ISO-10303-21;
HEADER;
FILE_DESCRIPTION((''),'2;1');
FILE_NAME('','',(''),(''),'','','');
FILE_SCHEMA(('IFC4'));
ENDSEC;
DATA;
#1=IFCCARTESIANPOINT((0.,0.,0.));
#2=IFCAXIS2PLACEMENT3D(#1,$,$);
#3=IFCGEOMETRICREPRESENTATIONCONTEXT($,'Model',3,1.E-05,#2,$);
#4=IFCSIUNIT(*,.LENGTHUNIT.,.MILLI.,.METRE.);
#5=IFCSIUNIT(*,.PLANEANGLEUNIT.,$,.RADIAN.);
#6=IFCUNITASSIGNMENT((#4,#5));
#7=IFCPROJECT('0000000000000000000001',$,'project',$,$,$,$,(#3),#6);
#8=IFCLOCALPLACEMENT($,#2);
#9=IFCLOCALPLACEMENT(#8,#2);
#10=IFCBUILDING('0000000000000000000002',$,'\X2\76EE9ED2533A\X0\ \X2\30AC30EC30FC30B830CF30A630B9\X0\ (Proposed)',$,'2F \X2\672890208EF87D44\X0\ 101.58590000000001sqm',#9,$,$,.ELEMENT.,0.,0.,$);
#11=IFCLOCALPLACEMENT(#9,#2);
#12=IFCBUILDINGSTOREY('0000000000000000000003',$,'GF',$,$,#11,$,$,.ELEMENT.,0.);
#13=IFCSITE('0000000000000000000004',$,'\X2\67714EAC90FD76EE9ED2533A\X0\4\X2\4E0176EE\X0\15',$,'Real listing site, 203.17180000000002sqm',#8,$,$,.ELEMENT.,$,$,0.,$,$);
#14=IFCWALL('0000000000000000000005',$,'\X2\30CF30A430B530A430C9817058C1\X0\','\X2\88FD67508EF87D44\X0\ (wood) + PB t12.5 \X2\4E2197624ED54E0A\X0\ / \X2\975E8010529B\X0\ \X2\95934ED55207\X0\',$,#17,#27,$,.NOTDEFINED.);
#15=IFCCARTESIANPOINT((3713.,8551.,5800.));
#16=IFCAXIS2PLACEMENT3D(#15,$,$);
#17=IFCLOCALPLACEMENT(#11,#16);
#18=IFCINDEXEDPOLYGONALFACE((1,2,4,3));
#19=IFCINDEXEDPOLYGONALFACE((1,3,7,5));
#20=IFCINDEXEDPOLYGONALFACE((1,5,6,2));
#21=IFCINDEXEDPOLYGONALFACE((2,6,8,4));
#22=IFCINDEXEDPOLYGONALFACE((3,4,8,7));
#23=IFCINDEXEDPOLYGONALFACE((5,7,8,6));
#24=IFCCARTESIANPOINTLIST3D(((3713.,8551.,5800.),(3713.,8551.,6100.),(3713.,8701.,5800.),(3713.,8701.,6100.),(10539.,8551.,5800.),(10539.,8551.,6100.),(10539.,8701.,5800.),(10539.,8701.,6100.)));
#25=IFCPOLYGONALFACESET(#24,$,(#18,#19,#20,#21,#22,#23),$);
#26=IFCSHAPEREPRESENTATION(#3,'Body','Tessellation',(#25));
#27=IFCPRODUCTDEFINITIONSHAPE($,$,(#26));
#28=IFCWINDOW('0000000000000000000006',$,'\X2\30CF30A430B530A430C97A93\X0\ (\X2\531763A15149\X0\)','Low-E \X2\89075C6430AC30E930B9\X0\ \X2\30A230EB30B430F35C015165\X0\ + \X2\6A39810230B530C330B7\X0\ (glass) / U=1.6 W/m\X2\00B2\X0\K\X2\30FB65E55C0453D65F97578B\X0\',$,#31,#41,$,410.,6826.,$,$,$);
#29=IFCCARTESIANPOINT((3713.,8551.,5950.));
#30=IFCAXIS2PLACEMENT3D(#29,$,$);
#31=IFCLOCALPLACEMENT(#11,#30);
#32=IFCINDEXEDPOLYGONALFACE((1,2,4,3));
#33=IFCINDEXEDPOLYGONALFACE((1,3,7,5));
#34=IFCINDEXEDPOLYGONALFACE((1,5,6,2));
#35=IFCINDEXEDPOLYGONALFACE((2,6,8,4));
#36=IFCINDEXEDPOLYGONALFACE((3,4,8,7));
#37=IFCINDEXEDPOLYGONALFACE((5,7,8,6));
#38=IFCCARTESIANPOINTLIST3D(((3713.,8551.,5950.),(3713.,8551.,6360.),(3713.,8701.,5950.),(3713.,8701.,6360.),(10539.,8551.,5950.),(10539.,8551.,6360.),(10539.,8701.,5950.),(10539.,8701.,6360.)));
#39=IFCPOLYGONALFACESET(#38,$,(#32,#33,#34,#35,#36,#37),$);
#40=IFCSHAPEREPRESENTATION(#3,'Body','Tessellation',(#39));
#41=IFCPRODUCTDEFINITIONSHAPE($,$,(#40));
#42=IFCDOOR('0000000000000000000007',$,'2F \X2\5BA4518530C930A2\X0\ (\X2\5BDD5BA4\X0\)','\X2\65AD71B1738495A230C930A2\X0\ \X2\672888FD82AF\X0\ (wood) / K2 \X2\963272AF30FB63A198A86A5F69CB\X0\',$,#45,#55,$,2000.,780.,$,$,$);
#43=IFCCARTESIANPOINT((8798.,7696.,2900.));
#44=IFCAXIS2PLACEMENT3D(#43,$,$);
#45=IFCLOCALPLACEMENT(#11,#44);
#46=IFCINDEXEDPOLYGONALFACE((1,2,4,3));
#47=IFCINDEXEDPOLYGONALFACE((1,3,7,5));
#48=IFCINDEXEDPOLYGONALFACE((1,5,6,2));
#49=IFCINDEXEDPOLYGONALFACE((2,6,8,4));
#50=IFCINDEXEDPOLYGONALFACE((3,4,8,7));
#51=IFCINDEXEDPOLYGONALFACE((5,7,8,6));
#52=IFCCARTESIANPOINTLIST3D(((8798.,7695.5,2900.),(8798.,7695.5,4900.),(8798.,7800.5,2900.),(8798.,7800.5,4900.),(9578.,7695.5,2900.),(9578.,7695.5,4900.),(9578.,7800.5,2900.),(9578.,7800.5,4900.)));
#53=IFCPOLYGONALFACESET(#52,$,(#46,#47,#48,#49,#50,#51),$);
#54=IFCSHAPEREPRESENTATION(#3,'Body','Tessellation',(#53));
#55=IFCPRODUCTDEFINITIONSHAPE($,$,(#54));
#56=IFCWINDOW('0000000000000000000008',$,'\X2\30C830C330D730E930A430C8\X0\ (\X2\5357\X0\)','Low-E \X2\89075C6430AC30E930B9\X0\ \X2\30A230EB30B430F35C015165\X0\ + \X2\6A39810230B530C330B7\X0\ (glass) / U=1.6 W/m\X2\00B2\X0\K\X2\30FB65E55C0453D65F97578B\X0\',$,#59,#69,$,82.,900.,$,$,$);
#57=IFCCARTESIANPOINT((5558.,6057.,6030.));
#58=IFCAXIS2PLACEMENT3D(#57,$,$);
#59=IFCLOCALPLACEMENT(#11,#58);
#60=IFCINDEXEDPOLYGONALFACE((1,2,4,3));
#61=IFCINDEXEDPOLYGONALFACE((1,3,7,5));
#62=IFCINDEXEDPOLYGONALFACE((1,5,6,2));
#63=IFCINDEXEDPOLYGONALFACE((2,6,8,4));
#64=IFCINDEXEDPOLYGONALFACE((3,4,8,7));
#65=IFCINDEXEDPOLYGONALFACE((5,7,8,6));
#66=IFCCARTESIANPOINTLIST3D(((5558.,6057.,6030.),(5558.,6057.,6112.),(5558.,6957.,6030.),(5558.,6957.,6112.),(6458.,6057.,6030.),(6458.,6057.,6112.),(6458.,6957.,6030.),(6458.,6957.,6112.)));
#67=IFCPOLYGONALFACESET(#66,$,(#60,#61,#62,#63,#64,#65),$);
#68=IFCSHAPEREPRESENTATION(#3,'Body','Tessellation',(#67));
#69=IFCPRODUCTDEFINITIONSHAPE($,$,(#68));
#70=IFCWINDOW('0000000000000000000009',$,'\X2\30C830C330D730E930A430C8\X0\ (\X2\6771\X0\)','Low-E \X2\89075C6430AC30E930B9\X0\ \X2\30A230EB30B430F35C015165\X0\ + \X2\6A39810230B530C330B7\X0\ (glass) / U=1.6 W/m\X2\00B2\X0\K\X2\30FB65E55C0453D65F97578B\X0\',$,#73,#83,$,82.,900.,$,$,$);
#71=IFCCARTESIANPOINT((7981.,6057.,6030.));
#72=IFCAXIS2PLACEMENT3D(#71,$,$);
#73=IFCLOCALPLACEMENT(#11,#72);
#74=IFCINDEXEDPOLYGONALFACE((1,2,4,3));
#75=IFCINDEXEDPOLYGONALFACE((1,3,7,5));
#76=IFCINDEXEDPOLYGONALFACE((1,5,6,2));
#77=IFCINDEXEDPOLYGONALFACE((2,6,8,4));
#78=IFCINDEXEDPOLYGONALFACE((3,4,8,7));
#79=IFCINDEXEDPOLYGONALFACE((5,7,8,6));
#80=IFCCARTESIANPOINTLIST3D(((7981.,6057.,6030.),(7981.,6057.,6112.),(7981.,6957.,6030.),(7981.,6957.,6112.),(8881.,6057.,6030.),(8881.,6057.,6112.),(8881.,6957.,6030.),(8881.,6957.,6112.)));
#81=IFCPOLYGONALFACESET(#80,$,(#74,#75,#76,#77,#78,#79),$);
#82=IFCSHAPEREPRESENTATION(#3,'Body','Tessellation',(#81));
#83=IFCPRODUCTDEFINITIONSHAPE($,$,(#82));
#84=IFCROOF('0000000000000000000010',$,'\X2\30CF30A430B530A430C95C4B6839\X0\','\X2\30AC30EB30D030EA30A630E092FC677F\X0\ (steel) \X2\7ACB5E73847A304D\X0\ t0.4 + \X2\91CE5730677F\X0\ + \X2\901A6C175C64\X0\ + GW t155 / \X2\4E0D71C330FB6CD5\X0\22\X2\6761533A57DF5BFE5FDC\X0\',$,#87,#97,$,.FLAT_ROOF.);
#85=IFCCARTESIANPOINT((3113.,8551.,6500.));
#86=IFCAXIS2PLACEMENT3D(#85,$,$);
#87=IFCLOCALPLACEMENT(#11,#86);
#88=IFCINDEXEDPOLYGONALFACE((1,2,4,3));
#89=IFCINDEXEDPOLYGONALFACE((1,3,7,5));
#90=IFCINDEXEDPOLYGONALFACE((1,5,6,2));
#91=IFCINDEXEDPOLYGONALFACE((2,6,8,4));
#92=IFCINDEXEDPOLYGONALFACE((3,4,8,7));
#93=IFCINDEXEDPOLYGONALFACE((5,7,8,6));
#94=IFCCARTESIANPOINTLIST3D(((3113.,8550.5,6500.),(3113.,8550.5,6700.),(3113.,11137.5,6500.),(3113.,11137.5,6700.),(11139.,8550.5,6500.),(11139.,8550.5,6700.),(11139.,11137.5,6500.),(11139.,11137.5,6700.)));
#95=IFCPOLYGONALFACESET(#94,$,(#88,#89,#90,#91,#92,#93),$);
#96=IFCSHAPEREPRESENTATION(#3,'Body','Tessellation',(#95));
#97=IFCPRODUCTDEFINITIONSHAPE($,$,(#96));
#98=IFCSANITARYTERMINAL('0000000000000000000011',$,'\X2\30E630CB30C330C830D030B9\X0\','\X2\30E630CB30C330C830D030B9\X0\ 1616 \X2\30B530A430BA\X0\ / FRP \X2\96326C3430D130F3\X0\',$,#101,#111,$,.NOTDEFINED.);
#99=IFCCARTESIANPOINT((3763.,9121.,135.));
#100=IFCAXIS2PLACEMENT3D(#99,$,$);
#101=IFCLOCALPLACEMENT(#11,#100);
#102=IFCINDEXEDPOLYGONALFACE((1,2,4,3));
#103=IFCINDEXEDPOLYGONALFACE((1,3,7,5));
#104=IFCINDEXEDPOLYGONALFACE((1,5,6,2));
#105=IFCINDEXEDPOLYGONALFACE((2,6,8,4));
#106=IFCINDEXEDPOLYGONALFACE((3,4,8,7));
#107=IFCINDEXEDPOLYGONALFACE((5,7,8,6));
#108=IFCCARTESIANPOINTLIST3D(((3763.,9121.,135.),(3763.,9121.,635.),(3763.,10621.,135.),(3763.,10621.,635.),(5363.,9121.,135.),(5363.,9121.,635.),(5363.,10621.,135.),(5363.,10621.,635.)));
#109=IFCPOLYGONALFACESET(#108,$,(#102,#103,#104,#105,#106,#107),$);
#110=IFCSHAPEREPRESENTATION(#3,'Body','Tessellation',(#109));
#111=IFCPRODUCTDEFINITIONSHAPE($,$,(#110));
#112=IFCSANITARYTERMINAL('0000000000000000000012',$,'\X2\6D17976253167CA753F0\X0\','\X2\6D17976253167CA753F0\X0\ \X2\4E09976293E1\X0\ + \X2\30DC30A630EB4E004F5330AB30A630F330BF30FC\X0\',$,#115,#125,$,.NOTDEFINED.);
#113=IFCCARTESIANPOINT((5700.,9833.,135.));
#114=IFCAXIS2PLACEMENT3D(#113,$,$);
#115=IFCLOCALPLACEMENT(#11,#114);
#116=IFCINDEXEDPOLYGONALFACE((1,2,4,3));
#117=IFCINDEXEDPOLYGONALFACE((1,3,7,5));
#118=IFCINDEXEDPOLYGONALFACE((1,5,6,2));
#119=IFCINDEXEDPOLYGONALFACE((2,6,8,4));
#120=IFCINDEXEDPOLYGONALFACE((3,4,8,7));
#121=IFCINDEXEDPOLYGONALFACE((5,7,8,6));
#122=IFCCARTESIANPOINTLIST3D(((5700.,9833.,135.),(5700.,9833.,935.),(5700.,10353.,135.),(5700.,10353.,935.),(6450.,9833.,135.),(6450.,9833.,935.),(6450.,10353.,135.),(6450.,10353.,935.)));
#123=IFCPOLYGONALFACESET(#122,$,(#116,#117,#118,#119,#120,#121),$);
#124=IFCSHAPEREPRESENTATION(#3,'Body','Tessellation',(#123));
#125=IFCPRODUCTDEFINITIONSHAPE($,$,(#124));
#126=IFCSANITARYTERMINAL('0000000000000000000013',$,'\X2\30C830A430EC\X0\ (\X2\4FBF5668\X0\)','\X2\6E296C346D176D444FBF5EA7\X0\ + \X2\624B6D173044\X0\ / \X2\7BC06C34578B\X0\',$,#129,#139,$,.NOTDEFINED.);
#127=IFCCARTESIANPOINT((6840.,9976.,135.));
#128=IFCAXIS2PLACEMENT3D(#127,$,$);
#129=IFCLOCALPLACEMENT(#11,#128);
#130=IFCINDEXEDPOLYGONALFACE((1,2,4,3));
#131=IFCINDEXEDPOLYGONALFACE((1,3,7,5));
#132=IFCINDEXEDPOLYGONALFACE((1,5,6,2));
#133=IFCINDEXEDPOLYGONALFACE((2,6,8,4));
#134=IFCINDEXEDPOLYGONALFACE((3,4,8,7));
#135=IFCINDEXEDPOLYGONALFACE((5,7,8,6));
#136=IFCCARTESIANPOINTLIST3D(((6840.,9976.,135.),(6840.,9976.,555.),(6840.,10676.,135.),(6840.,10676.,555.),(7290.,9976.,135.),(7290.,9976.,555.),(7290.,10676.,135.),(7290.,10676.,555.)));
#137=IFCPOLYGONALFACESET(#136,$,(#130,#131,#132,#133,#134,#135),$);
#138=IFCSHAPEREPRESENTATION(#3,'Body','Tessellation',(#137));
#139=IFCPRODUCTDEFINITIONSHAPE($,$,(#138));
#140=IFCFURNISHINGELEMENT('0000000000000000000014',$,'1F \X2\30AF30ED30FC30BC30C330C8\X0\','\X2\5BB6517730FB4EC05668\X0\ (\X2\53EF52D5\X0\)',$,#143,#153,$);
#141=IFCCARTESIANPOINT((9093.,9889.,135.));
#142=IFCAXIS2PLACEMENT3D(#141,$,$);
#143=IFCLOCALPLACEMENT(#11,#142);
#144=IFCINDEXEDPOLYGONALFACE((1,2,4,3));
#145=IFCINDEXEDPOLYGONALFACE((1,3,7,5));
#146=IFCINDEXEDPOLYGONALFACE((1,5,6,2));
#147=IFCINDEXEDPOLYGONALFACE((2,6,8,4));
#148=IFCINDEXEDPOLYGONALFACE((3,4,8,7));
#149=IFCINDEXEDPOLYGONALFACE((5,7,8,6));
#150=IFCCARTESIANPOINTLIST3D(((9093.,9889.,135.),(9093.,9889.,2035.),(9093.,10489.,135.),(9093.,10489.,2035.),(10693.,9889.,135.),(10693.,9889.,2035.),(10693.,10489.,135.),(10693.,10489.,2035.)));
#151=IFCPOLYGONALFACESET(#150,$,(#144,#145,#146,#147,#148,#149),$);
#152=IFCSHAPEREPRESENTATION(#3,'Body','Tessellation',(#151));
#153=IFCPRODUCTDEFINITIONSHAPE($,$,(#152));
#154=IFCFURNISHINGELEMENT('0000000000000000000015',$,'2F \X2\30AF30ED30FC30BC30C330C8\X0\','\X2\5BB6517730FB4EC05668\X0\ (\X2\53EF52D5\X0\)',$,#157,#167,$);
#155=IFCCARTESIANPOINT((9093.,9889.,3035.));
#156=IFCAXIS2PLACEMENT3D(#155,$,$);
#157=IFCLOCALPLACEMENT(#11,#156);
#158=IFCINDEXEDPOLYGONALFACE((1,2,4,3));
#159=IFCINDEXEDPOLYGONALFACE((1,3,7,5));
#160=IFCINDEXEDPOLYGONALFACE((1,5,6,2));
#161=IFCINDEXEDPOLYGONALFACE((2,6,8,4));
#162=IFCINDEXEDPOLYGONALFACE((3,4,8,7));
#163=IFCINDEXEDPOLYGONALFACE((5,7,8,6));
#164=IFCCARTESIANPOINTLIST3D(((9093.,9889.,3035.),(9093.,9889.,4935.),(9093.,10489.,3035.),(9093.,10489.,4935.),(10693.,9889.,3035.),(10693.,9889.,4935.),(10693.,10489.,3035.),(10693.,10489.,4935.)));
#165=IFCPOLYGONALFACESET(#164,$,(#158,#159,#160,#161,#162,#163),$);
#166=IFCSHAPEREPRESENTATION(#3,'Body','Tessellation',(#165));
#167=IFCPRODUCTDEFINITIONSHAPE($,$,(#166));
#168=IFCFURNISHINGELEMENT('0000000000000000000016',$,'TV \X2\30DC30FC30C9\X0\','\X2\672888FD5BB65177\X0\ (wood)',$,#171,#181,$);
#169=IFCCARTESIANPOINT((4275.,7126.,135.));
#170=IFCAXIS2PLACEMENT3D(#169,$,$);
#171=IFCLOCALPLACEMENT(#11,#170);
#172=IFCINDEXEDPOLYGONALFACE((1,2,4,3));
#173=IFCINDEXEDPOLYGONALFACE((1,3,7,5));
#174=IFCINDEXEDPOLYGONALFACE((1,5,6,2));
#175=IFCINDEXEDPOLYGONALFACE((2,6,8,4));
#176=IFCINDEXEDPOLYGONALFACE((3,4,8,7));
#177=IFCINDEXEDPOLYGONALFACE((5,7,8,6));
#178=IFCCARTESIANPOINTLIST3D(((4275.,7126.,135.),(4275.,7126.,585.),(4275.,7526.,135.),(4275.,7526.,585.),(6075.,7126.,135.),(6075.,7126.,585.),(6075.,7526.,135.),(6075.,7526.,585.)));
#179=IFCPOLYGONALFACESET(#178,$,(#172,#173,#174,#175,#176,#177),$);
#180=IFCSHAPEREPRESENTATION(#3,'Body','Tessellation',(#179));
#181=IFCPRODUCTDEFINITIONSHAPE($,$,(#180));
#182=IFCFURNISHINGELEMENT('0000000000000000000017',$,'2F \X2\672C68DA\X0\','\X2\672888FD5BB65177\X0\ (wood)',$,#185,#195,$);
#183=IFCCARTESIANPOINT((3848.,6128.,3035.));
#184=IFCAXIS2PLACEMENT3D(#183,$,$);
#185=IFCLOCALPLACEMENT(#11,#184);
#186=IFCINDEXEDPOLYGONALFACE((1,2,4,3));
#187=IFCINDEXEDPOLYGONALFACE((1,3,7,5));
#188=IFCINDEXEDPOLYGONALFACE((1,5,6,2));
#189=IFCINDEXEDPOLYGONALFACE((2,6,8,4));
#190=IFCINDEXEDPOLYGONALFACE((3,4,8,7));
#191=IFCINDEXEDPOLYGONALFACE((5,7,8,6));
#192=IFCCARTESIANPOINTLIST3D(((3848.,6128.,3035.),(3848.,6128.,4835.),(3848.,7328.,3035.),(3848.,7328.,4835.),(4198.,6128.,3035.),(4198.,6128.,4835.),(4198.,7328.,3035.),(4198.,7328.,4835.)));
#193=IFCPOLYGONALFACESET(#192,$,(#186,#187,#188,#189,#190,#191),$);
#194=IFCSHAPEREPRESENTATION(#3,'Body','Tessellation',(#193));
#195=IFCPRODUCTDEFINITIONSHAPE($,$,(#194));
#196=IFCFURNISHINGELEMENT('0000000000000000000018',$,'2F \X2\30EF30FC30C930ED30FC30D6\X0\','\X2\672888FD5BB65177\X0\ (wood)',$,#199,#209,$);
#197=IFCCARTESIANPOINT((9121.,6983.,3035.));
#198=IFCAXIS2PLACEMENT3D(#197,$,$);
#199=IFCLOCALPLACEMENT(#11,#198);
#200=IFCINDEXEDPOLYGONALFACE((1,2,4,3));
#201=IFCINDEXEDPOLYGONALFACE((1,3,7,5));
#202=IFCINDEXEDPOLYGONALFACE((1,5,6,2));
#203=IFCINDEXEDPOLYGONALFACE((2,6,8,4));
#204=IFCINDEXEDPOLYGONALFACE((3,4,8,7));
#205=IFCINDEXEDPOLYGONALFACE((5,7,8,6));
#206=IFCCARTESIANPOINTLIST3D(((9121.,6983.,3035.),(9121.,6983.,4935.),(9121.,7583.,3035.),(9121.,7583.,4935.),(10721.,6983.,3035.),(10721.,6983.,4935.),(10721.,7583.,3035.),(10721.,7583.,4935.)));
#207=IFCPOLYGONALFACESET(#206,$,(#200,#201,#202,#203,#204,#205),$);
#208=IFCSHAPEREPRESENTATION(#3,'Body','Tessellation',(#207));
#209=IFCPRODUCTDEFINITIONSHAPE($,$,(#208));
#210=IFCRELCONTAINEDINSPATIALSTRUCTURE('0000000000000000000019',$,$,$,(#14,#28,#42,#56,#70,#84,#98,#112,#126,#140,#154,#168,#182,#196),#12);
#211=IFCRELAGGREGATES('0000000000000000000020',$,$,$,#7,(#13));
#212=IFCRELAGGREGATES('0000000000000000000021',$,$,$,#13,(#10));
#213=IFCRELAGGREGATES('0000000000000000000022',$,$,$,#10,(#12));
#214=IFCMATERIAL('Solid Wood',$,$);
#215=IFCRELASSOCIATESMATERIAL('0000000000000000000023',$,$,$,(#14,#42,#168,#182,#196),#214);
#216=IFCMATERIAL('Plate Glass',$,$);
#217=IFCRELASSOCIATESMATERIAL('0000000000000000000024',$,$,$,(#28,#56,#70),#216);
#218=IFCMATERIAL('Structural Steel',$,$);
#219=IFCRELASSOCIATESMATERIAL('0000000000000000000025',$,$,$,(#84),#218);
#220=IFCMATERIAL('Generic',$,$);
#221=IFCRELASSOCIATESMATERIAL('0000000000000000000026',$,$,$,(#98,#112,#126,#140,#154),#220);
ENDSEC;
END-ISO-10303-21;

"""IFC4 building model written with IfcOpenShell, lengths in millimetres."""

from ifc_helpers import new_model, si_unit, frame, frame_2d, origin, place, context, project, spatial, rectangle, extrude, material, element, fill, save


model = new_model("IFC4")

# Units and contexts
model_context = context("Model", 3, precision=1e-05, world=origin())
ifc_project = project(units=[si_unit("LENGTHUNIT", "METRE", prefix="MILLI"), si_unit("PLANEANGLEUNIT", "RADIAN")], contexts=[model_context])

# Site, building, storey
site_placement = place(None, origin())
site = spatial("IfcSite", under=ifc_project, at=site_placement, Name="東京都目黒区4丁目15", ObjectType="Real listing site, 203.17180000000002sqm", CompositionType="ELEMENT", RefElevation=0.0)
building_placement = place(site_placement, origin())
building = spatial("IfcBuilding", under=site, at=building_placement, Name="目黒区 ガレージハウス (Proposed)", ObjectType="2F 木造軸組 101.58590000000001sqm", CompositionType="ELEMENT", ElevationOfRefHeight=0.0, ElevationOfTerrain=0.0)
storey_placement = place(building_placement, origin())
storey = spatial("IfcBuildingStorey", under=building, at=storey_placement, Name="GF", CompositionType="ELEMENT", Elevation=0.0)

# Shared definitions
ifc_material_1 = material(Name="Solid Wood")
ifc_material_2 = material(Name="Plate Glass")

# Wall, opening, window
wall_1_placement = place(storey_placement, frame((3713.0, 8551.0, 5800.0)))
wall_1 = element("IfcWall", 1, at=wall_1_placement, inside=storey, material=ifc_material_1, Name="ハイサイド腰壁", Description="製材軸組 (wood) + PB t12.5 両面仕上 / 非耐力 間仕切", PredefinedType="NOTDEFINED", context=model_context, shape_type="SweptSolid", body=[
    extrude(rectangle(XDim=6826.0, YDim=150.0, at=frame_2d((3413.0, 75.0))), frame((3713.0, 8551.0, 5800.0)), (0.0, 0.0, 1.0), 700.0),
])
opening_1_placement = place(storey_placement, frame((3713.0, 8551.0, 5950.0)))
opening_1 = element("IfcOpeningElement", 2, at=opening_1_placement, cuts=wall_1, PredefinedType="NOTDEFINED", context=model_context, shape_type="SweptSolid", body=[
    extrude(rectangle(XDim=6826.0, YDim=150.0, at=frame_2d((3413.0, 75.0))), frame((3713.0, 8551.0, 5950.0)), (0.0, 0.0, 1.0), 410.0),
])
window_1_placement = place(storey_placement, frame((3713.0, 8551.0, 5950.0)))
window_1 = element("IfcWindow", 3, at=window_1_placement, inside=storey, material=ifc_material_2, Name="ハイサイド窓 (北採光)", Description="Low-E 複層ガラス アルゴン封入 + 樹脂サッシ (glass) / U=1.6 W/m²K・日射取得型", OverallHeight=410.0, OverallWidth=6826.0, context=model_context, shape_type="SweptSolid", body=[
    extrude(rectangle(XDim=6826.0, YDim=150.0, at=frame_2d((3413.0, 75.0))), frame((3713.0, 8551.0, 5950.0)), (0.0, 0.0, 1.0), 410.0),
])
fill(opening_1, window_1)

# Door
door_1_placement = place(storey_placement, frame((8798.0, 7696.0, 2900.0)))
element("IfcDoor", 4, at=door_1_placement, inside=storey, material=ifc_material_1, Name="2F 室内ドア (寝室)", Description="断熱玄関ドア 木製芯 (wood) / K2 防犯・採風機構", OverallHeight=2000.0, OverallWidth=780.0, context=model_context, shape_type="SweptSolid", body=[
    extrude(rectangle(XDim=780.0, YDim=105.0, at=frame_2d((390.0, 52.0))), frame((8798.0, 7696.0, 2900.0)), (0.0, 0.0, 1.0), 2000.0),
])

# Windows
window_2_placement = place(storey_placement, frame((5558.0, 6057.0, 6030.0)))
element("IfcWindow", 5, at=window_2_placement, inside=storey, material=ifc_material_2, Name="トップライト (南)", Description="Low-E 複層ガラス アルゴン封入 + 樹脂サッシ (glass) / U=1.6 W/m²K・日射取得型", OverallHeight=82.0, OverallWidth=900.0, context=model_context, shape_type="SweptSolid", body=[
    extrude(rectangle(XDim=900.0, YDim=900.0, at=frame_2d((450.0, 450.0))), frame((5558.0, 6057.0, 6030.0)), (0.0, 0.0, 1.0), 82.0),
])
window_3_placement = place(storey_placement, frame((7981.0, 6057.0, 6030.0)))
element("IfcWindow", 6, at=window_3_placement, inside=storey, material=ifc_material_2, Name="トップライト (東)", Description="Low-E 複層ガラス アルゴン封入 + 樹脂サッシ (glass) / U=1.6 W/m²K・日射取得型", OverallHeight=82.0, OverallWidth=900.0, context=model_context, shape_type="SweptSolid", body=[
    extrude(rectangle(XDim=900.0, YDim=900.0, at=frame_2d((450.0, 450.0))), frame((7981.0, 6057.0, 6030.0)), (0.0, 0.0, 1.0), 82.0),
])

# Roof
ifc_material_3 = material(Name="Structural Steel")
roof_placement = place(storey_placement, frame((3113.0, 8551.0, 6500.0)))
element("IfcRoof", 7, at=roof_placement, inside=storey, material=ifc_material_3, Name="ハイサイド屋根", Description="ガルバリウム鋼板 (steel) 立平葺き t0.4 + 野地板 + 通気層 + GW t155 / 不燃・法22条区域対応", PredefinedType="FLAT_ROOF", context=model_context, shape_type="SweptSolid", body=[
    extrude(rectangle(XDim=8026.0, YDim=2587.0, at=frame_2d((4013.0, 1293.0))), frame((3113.0, 8551.0, 6500.0)), (0.0, 0.0, 1.0), 200.0),
])

# Sanitary terminals
ifc_material_4 = material(Name="Generic")
sanitary_terminal_1_placement = place(storey_placement, frame((3763.0, 9121.0, 135.0)))
element("IfcSanitaryTerminal", 8, at=sanitary_terminal_1_placement, inside=storey, material=ifc_material_4, Name="ユニットバス", Description="ユニットバス 1616 サイズ / FRP 防水パン", PredefinedType="NOTDEFINED", context=model_context, shape_type="SweptSolid", body=[
    extrude(rectangle(XDim=1600.0, YDim=1500.0, at=frame_2d((800.0, 750.0))), frame((3763.0, 9121.0, 135.0)), (0.0, 0.0, 1.0), 500.0),
])
sanitary_terminal_2_placement = place(storey_placement, frame((5700.0, 9833.0, 135.0)))
element("IfcSanitaryTerminal", 9, at=sanitary_terminal_2_placement, inside=storey, material=ifc_material_4, Name="洗面化粧台", Description="洗面化粧台 三面鏡 + ボウル一体カウンター", PredefinedType="NOTDEFINED", context=model_context, shape_type="SweptSolid", body=[
    extrude(rectangle(XDim=750.0, YDim=520.0, at=frame_2d((375.0, 260.0))), frame((5700.0, 9833.0, 135.0)), (0.0, 0.0, 1.0), 800.0),
])
sanitary_terminal_3_placement = place(storey_placement, frame((6840.0, 9976.0, 135.0)))
element("IfcSanitaryTerminal", 10, at=sanitary_terminal_3_placement, inside=storey, material=ifc_material_4, Name="トイレ (便器)", Description="温水洗浄便座 + 手洗い / 節水型", PredefinedType="NOTDEFINED", context=model_context, shape_type="SweptSolid", body=[
    extrude(rectangle(XDim=450.0, YDim=700.0, at=frame_2d((225.0, 350.0))), frame((6840.0, 9976.0, 135.0)), (0.0, 0.0, 1.0), 420.0),
])

# Furnishing elements
furnishing_1_placement = place(storey_placement, frame((9093.0, 9889.0, 135.0)))
element("IfcFurnishingElement", 11, at=furnishing_1_placement, inside=storey, material=ifc_material_4, Name="1F クローゼット", Description="家具・什器 (可動)", context=model_context, shape_type="SweptSolid", body=[
    extrude(rectangle(XDim=1600.0, YDim=600.0, at=frame_2d((800.0, 300.0))), frame((9093.0, 9889.0, 135.0)), (0.0, 0.0, 1.0), 1900.0),
])
furnishing_2_placement = place(storey_placement, frame((9093.0, 9889.0, 3035.0)))
element("IfcFurnishingElement", 12, at=furnishing_2_placement, inside=storey, material=ifc_material_4, Name="2F クローゼット", Description="家具・什器 (可動)", context=model_context, shape_type="SweptSolid", body=[
    extrude(rectangle(XDim=1600.0, YDim=600.0, at=frame_2d((800.0, 300.0))), frame((9093.0, 9889.0, 3035.0)), (0.0, 0.0, 1.0), 1900.0),
])
furnishing_3_placement = place(storey_placement, frame((4275.0, 7126.0, 135.0)))
element("IfcFurnishingElement", 13, at=furnishing_3_placement, inside=storey, material=ifc_material_1, Name="TV ボード", Description="木製家具 (wood)", context=model_context, shape_type="SweptSolid", body=[
    extrude(rectangle(XDim=1800.0, YDim=400.0, at=frame_2d((900.0, 200.0))), frame((4275.0, 7126.0, 135.0)), (0.0, 0.0, 1.0), 450.0),
])
furnishing_4_placement = place(storey_placement, frame((3848.0, 6128.0, 3035.0)))
element("IfcFurnishingElement", 14, at=furnishing_4_placement, inside=storey, material=ifc_material_1, Name="2F 本棚", Description="木製家具 (wood)", context=model_context, shape_type="SweptSolid", body=[
    extrude(rectangle(XDim=350.0, YDim=1200.0, at=frame_2d((175.0, 600.0))), frame((3848.0, 6128.0, 3035.0)), (0.0, 0.0, 1.0), 1800.0),
])
furnishing_5_placement = place(storey_placement, frame((9121.0, 6983.0, 3035.0)))
element("IfcFurnishingElement", 15, at=furnishing_5_placement, inside=storey, material=ifc_material_1, Name="2F ワードローブ", Description="木製家具 (wood)", context=model_context, shape_type="SweptSolid", body=[
    extrude(rectangle(XDim=1600.0, YDim=600.0, at=frame_2d((800.0, 300.0))), frame((9121.0, 6983.0, 3035.0)), (0.0, 0.0, 1.0), 1900.0),
])

save(model, "model.ifc")
